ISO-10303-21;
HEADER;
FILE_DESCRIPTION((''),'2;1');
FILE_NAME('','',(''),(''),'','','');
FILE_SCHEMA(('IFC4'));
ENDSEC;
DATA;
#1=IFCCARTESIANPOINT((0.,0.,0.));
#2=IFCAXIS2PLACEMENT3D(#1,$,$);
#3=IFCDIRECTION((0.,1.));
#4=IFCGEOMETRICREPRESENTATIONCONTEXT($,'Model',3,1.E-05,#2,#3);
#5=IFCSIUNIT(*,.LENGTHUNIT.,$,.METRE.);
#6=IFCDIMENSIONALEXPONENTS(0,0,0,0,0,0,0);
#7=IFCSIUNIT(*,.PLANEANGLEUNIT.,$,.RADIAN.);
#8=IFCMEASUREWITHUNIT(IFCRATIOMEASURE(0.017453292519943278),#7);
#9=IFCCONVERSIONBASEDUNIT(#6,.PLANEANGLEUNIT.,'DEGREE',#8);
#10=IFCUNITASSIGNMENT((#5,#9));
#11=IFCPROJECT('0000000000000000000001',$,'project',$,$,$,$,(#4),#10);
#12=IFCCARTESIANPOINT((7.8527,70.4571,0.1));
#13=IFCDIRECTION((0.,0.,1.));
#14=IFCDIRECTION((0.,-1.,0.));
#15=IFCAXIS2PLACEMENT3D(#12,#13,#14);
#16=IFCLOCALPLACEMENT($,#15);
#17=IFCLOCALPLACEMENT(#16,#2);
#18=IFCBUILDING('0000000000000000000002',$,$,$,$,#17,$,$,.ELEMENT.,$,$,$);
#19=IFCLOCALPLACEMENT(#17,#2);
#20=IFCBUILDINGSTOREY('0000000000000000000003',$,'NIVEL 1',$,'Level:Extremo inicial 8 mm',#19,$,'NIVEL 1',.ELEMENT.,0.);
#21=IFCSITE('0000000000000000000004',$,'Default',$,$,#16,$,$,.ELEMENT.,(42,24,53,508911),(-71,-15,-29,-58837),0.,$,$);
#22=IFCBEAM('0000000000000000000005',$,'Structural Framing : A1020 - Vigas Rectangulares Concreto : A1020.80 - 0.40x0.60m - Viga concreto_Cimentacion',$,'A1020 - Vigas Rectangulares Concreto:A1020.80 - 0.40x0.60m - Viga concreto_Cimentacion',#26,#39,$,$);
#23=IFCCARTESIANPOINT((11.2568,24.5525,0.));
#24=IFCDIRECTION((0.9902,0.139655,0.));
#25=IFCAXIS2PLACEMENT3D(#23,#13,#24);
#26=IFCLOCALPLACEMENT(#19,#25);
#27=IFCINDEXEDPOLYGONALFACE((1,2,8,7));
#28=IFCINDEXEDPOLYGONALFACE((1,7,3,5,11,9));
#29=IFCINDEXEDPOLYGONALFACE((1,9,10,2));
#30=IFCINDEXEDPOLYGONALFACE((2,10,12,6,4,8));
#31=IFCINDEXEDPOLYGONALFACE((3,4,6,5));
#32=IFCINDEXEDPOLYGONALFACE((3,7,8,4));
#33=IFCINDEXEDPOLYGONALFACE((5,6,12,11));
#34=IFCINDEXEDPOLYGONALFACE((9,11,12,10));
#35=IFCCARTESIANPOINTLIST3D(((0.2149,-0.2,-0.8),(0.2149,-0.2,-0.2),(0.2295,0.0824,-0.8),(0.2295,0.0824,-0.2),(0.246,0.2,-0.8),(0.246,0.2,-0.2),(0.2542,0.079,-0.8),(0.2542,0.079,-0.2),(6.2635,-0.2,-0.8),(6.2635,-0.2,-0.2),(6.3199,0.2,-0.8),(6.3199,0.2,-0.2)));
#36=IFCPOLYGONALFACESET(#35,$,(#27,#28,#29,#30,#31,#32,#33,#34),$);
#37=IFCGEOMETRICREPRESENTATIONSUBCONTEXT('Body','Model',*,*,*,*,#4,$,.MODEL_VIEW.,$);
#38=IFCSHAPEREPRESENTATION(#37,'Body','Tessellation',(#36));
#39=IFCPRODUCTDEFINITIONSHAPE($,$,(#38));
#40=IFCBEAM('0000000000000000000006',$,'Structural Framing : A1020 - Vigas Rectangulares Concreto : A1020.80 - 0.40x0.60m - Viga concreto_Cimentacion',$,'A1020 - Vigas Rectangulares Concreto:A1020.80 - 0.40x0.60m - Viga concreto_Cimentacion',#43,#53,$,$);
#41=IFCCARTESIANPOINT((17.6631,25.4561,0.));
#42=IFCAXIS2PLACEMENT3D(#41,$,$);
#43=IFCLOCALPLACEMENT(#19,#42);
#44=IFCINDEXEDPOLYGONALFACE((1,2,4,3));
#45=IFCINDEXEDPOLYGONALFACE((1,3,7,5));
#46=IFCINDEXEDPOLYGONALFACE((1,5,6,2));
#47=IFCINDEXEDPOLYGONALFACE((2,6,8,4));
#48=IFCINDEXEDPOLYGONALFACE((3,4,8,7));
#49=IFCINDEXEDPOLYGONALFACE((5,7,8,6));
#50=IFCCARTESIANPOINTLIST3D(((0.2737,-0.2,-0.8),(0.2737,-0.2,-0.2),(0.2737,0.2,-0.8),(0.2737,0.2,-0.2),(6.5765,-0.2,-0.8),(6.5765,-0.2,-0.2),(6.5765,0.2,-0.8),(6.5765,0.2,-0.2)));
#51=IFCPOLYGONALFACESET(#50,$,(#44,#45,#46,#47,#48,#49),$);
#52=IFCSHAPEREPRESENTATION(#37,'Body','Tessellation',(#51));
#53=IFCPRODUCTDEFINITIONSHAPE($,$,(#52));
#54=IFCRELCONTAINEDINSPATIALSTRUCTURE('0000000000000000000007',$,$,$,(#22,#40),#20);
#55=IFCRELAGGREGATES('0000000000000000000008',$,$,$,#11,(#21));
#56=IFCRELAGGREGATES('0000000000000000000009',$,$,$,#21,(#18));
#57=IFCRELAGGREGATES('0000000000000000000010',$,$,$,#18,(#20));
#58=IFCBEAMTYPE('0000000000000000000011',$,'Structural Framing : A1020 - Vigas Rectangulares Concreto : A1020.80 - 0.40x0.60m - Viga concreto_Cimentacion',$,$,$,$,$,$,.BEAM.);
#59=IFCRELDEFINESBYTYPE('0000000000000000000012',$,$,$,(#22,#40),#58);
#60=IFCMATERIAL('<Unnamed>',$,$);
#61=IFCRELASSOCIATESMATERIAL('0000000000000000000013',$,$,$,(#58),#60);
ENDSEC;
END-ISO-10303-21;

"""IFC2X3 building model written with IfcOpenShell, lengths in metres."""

from ifc_helpers import new_model, entity, si_unit, converted_unit, direction, frame, frame_2d, origin, place, context, subcontext, project, spatial, polyline, rectangle, extrude, clip, halfspace, bounded_halfspace, material, type_object, element, save


model = new_model("IFC2X3")

# Units and contexts
model_context = context("Model", 3, precision=1e-05, world=origin(), true_north=direction((0.0, 1.0)))
body_context = subcontext(model_context, "Body", "Model", "MODEL_VIEW")
ifc_project = project(units=[si_unit("LENGTHUNIT", "METRE"), converted_unit("PLANEANGLEUNIT", "DEGREE", entity("IfcRatioMeasure", 0.017453292519943278), si_unit("PLANEANGLEUNIT", "RADIAN"), dimensions=[0, 0, 0, 0, 0, 0, 0])], contexts=[model_context])

# Site, building, storey
site_placement = place(None, frame((7.8527, 70.4571, 0.1), z_axis=(0.0, 0.0, 1.0), x_axis=(0.0, -1.0, 0.0)))
site = spatial("IfcSite", under=ifc_project, at=site_placement, Name="Default", CompositionType="ELEMENT", RefLatitude=(42, 24, 53, 508911), RefLongitude=(-71, -15, -29, -58837), RefElevation=0.0)
building_placement = place(site_placement, origin())
building = spatial("IfcBuilding", under=site, at=building_placement, CompositionType="ELEMENT")
storey_placement = place(building_placement, origin())
storey = spatial("IfcBuildingStorey", under=building, at=storey_placement, Name="NIVEL 1", ObjectType="Level:Extremo inicial 8 mm", LongName="NIVEL 1", CompositionType="ELEMENT", Elevation=0.0)

# Shared definitions
ifc_material_1 = material(Name="<Unnamed>")

# Beams
beam_type_1 = type_object("IfcBeamType", Name="Structural Framing : A1020 - Vigas Rectangulares Concreto : A1020.80 - 0.40x0.60m - Viga concreto_Cimentacion", PredefinedType="BEAM", material=ifc_material_1)
beam_1_placement = place(storey_placement, frame((11.2568, 24.5525, 0.0), z_axis=(0.0, 0.0, 1.0), x_axis=(0.9902, 0.139655, 0.0)))
element("IfcBeam", 1, at=beam_1_placement, inside=storey, type_object=beam_type_1, Name="Structural Framing : A1020 - Vigas Rectangulares Concreto : A1020.80 - 0.40x0.60m - Viga concreto_Cimentacion", ObjectType="A1020 - Vigas Rectangulares Concreto:A1020.80 - 0.40x0.60m - Viga concreto_Cimentacion", context=body_context, shape_type="SweptSolid", body=[
    clip(clip(clip(clip(extrude(rectangle(XDim=0.6, YDim=0.4, at=frame_2d((0.0, 0.0), x_axis=(1.0, 0.0))), frame((0.2149, 0.0, -0.5), z_axis=(1.0, 0.0, 0.0), x_axis=(0.0, 0.0, -1.0)), (0.0, 0.0, 1.0), 6.105), halfspace(frame((0.1648, -0.3757, -0.2), z_axis=(-0.9902, 0.139655, 0.0), x_axis=(-0.139655, -0.9902, 0.0)), False)), halfspace(frame((6.3231, 0.2227, 3.0), z_axis=(0.9902, -0.139655, 0.0), x_axis=(0.0, 0.0, -1.0)), False)), bounded_halfspace(frame((0.1914, -0.3666, 3.0), z_axis=(-0.9902, 0.139655, 0.0), x_axis=(0.0, 0.0, -1.0)), False, frame((0.2149, 0.0, -0.5), z_axis=(1.0, 0.0, 0.0), x_axis=(0.0, 0.0, -1.0)), polyline([(0.3, -0.2), (-0.3, -0.2), (-0.3, 0.079), (0.3, 0.079), (0.3, -0.2)]))), bounded_halfspace(frame((0.2542, 0.079, 3.0), z_axis=(-0.139655, -0.9902, 0.0), x_axis=(0.0, 0.0, -1.0)), False, frame((0.2149, 0.0, -0.5), z_axis=(1.0, 0.0, 0.0), x_axis=(0.0, 0.0, -1.0)), polyline([(0.3, 0.079), (-0.3, 0.079), (-0.3, 0.0824), (0.3, 0.0824), (0.3, 0.079)]))),
])
beam_2_placement = place(storey_placement, frame((17.6631, 25.4561, 0.0)))
element("IfcBeam", 2, at=beam_2_placement, inside=storey, type_object=beam_type_1, Name="Structural Framing : A1020 - Vigas Rectangulares Concreto : A1020.80 - 0.40x0.60m - Viga concreto_Cimentacion", ObjectType="A1020 - Vigas Rectangulares Concreto:A1020.80 - 0.40x0.60m - Viga concreto_Cimentacion", context=body_context, shape_type="SweptSolid", body=[
    extrude(rectangle(XDim=0.6, YDim=0.4, at=frame_2d((0.0, 0.0), x_axis=(1.0, 0.0))), frame((0.2737, 0.0, -0.5), z_axis=(1.0, 0.0, 0.0), x_axis=(0.0, 0.0, -1.0)), (0.0, 0.0, 1.0), 6.3028),
])

save(model, "model.ifc")
